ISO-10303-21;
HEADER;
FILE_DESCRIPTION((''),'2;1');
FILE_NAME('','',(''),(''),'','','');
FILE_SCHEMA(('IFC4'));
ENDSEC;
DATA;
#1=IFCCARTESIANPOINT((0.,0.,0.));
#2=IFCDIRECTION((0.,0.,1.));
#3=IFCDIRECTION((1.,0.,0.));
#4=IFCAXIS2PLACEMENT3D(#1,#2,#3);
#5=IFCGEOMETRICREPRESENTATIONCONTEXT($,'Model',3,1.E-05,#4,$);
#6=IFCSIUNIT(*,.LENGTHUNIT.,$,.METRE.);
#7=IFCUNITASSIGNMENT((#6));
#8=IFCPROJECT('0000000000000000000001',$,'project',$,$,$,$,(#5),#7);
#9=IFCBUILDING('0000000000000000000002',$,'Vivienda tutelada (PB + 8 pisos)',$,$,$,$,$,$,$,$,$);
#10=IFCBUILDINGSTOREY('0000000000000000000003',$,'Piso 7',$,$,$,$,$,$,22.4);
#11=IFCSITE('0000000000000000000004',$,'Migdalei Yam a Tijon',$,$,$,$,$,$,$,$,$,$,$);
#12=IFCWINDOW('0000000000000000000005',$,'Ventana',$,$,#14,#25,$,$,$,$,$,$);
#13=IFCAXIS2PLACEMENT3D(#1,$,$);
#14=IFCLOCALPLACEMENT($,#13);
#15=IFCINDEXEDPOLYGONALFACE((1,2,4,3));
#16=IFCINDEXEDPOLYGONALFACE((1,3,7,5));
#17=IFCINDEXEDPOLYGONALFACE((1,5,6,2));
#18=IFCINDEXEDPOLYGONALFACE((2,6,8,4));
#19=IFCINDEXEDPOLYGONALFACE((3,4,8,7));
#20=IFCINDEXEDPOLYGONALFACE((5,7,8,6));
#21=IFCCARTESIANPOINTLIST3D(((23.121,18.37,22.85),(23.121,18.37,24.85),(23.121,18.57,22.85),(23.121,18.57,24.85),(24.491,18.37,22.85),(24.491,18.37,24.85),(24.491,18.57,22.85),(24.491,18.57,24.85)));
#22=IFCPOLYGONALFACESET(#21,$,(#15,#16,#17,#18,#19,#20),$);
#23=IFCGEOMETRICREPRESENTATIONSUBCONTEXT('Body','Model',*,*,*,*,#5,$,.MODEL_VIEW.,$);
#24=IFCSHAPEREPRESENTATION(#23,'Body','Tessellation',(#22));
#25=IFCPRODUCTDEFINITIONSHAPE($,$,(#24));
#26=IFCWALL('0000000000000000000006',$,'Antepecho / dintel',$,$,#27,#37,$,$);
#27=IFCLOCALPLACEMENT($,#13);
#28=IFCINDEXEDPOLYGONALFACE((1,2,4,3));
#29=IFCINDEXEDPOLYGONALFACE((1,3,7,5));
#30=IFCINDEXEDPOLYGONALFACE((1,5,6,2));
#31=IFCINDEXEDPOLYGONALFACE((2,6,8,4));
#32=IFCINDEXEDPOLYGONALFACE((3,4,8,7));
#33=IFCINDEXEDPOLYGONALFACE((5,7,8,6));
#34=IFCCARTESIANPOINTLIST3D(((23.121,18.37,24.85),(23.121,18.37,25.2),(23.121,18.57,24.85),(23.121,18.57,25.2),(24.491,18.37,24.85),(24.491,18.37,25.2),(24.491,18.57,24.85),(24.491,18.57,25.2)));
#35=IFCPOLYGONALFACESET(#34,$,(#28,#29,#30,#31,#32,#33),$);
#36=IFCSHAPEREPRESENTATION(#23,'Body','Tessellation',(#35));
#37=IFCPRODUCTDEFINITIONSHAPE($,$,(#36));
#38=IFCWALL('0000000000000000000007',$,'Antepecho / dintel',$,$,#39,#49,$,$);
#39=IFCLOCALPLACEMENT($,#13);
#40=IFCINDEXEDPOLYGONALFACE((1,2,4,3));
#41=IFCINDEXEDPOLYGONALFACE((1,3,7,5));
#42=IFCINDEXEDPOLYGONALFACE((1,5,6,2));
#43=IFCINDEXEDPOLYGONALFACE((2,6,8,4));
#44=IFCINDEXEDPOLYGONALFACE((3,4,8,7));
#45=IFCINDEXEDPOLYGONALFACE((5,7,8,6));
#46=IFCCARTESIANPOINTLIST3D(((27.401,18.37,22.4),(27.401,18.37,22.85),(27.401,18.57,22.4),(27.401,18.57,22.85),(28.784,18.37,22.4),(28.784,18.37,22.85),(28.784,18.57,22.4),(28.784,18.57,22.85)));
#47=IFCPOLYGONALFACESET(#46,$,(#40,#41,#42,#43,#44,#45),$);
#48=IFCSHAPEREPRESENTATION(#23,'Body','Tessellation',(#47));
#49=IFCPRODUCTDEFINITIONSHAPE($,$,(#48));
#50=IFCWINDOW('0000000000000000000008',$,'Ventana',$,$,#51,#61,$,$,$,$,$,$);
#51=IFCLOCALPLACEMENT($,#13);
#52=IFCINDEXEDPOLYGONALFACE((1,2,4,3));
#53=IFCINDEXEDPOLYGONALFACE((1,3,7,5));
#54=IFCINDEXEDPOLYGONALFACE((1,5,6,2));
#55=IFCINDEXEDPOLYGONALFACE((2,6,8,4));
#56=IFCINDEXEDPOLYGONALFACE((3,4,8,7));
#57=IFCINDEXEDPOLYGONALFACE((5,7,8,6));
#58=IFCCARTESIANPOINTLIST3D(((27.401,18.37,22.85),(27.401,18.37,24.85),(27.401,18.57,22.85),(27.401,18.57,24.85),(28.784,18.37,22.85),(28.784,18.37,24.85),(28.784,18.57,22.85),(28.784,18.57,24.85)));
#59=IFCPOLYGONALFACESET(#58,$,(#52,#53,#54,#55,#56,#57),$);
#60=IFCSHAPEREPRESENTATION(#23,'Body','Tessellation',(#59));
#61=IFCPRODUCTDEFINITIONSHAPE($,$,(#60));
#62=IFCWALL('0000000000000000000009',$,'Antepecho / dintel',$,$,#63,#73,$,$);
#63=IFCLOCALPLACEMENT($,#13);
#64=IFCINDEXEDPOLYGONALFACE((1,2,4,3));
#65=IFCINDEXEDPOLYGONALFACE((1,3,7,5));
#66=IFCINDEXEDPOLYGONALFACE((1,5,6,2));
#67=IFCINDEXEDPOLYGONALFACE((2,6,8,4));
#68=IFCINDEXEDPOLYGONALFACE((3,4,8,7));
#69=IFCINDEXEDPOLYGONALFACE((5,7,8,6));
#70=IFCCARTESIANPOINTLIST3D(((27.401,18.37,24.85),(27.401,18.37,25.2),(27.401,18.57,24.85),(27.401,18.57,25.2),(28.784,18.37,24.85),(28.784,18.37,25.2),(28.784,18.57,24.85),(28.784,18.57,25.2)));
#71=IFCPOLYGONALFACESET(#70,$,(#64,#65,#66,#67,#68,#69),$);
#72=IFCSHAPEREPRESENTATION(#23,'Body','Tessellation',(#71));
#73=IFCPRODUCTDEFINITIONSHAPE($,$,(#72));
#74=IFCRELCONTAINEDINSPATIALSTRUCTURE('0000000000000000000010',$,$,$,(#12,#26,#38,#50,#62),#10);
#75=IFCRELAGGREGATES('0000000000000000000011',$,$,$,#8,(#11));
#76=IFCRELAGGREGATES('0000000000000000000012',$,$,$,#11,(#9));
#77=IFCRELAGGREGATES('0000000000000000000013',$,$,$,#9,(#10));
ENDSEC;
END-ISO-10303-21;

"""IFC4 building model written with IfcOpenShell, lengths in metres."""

from ifc_helpers import new_model, si_unit, frame, origin_with_axes, context, subcontext, project, spatial, line, indexed_curve, outline, extrude, element, save


model = new_model("IFC4")

# Units and contexts
model_context = context("Model", 3, precision=1e-05, world=origin_with_axes())
body_context = subcontext(model_context, "Body", "Model", "MODEL_VIEW")
ifc_project = project(units=[si_unit("LENGTHUNIT", "METRE")], contexts=[model_context])

# Site, building, storey
site = spatial("IfcSite", under=ifc_project, Name="Migdalei Yam a Tijon")
building = spatial("IfcBuilding", under=site, Name="Vivienda tutelada (PB + 8 pisos)")
storey = spatial("IfcBuildingStorey", under=building, Name="Piso 7", Elevation=22.4)

# Window
element("IfcWindow", 1, inside=storey, Name="Ventana", context=body_context, shape_type="SweptSolid", body=[
    extrude(outline(indexed_curve([(0.0, 0.0), (1.37, 0.0), (1.37, 0.2), (0.0, 0.2)], segments=[line(1, 2, 3, 4, 1)])), frame((23.121, 18.37, 22.85), z_axis=(0.0, 0.0, 1.0), x_axis=(1.0, 0.0, 0.0)), (0.0, 0.0, 1.0), 2.0),
])

# Walls
element("IfcWall", 2, inside=storey, Name="Antepecho / dintel", context=body_context, shape_type="SweptSolid", body=[
    extrude(outline(indexed_curve([(0.0, 0.0), (1.37, 0.0), (1.37, 0.2), (0.0, 0.2)], segments=[line(1, 2, 3, 4, 1)])), frame((23.121, 18.37, 24.85), z_axis=(0.0, 0.0, 1.0), x_axis=(1.0, 0.0, 0.0)), (0.0, 0.0, 1.0), 0.35),
])
element("IfcWall", 3, inside=storey, Name="Antepecho / dintel", context=body_context, shape_type="SweptSolid", body=[
    extrude(outline(indexed_curve([(0.0, 0.0), (1.383, 0.0), (1.383, 0.2), (0.0, 0.2)], segments=[line(1, 2, 3, 4, 1)])), frame((27.401, 18.37, 22.4), z_axis=(0.0, 0.0, 1.0), x_axis=(1.0, 0.0, 0.0)), (0.0, 0.0, 1.0), 0.45),
])

# Window
element("IfcWindow", 4, inside=storey, Name="Ventana", context=body_context, shape_type="SweptSolid", body=[
    extrude(outline(indexed_curve([(0.0, 0.0), (1.383, 0.0), (1.383, 0.2), (0.0, 0.2)], segments=[line(1, 2, 3, 4, 1)])), frame((27.401, 18.37, 22.85), z_axis=(0.0, 0.0, 1.0), x_axis=(1.0, 0.0, 0.0)), (0.0, 0.0, 1.0), 2.0),
])

# Wall
element("IfcWall", 5, inside=storey, Name="Antepecho / dintel", context=body_context, shape_type="SweptSolid", body=[
    extrude(outline(indexed_curve([(0.0, 0.0), (1.383, 0.0), (1.383, 0.2), (0.0, 0.2)], segments=[line(1, 2, 3, 4, 1)])), frame((27.401, 18.37, 24.85), z_axis=(0.0, 0.0, 1.0), x_axis=(1.0, 0.0, 0.0)), (0.0, 0.0, 1.0), 0.35),
])

save(model, "model.ifc")
